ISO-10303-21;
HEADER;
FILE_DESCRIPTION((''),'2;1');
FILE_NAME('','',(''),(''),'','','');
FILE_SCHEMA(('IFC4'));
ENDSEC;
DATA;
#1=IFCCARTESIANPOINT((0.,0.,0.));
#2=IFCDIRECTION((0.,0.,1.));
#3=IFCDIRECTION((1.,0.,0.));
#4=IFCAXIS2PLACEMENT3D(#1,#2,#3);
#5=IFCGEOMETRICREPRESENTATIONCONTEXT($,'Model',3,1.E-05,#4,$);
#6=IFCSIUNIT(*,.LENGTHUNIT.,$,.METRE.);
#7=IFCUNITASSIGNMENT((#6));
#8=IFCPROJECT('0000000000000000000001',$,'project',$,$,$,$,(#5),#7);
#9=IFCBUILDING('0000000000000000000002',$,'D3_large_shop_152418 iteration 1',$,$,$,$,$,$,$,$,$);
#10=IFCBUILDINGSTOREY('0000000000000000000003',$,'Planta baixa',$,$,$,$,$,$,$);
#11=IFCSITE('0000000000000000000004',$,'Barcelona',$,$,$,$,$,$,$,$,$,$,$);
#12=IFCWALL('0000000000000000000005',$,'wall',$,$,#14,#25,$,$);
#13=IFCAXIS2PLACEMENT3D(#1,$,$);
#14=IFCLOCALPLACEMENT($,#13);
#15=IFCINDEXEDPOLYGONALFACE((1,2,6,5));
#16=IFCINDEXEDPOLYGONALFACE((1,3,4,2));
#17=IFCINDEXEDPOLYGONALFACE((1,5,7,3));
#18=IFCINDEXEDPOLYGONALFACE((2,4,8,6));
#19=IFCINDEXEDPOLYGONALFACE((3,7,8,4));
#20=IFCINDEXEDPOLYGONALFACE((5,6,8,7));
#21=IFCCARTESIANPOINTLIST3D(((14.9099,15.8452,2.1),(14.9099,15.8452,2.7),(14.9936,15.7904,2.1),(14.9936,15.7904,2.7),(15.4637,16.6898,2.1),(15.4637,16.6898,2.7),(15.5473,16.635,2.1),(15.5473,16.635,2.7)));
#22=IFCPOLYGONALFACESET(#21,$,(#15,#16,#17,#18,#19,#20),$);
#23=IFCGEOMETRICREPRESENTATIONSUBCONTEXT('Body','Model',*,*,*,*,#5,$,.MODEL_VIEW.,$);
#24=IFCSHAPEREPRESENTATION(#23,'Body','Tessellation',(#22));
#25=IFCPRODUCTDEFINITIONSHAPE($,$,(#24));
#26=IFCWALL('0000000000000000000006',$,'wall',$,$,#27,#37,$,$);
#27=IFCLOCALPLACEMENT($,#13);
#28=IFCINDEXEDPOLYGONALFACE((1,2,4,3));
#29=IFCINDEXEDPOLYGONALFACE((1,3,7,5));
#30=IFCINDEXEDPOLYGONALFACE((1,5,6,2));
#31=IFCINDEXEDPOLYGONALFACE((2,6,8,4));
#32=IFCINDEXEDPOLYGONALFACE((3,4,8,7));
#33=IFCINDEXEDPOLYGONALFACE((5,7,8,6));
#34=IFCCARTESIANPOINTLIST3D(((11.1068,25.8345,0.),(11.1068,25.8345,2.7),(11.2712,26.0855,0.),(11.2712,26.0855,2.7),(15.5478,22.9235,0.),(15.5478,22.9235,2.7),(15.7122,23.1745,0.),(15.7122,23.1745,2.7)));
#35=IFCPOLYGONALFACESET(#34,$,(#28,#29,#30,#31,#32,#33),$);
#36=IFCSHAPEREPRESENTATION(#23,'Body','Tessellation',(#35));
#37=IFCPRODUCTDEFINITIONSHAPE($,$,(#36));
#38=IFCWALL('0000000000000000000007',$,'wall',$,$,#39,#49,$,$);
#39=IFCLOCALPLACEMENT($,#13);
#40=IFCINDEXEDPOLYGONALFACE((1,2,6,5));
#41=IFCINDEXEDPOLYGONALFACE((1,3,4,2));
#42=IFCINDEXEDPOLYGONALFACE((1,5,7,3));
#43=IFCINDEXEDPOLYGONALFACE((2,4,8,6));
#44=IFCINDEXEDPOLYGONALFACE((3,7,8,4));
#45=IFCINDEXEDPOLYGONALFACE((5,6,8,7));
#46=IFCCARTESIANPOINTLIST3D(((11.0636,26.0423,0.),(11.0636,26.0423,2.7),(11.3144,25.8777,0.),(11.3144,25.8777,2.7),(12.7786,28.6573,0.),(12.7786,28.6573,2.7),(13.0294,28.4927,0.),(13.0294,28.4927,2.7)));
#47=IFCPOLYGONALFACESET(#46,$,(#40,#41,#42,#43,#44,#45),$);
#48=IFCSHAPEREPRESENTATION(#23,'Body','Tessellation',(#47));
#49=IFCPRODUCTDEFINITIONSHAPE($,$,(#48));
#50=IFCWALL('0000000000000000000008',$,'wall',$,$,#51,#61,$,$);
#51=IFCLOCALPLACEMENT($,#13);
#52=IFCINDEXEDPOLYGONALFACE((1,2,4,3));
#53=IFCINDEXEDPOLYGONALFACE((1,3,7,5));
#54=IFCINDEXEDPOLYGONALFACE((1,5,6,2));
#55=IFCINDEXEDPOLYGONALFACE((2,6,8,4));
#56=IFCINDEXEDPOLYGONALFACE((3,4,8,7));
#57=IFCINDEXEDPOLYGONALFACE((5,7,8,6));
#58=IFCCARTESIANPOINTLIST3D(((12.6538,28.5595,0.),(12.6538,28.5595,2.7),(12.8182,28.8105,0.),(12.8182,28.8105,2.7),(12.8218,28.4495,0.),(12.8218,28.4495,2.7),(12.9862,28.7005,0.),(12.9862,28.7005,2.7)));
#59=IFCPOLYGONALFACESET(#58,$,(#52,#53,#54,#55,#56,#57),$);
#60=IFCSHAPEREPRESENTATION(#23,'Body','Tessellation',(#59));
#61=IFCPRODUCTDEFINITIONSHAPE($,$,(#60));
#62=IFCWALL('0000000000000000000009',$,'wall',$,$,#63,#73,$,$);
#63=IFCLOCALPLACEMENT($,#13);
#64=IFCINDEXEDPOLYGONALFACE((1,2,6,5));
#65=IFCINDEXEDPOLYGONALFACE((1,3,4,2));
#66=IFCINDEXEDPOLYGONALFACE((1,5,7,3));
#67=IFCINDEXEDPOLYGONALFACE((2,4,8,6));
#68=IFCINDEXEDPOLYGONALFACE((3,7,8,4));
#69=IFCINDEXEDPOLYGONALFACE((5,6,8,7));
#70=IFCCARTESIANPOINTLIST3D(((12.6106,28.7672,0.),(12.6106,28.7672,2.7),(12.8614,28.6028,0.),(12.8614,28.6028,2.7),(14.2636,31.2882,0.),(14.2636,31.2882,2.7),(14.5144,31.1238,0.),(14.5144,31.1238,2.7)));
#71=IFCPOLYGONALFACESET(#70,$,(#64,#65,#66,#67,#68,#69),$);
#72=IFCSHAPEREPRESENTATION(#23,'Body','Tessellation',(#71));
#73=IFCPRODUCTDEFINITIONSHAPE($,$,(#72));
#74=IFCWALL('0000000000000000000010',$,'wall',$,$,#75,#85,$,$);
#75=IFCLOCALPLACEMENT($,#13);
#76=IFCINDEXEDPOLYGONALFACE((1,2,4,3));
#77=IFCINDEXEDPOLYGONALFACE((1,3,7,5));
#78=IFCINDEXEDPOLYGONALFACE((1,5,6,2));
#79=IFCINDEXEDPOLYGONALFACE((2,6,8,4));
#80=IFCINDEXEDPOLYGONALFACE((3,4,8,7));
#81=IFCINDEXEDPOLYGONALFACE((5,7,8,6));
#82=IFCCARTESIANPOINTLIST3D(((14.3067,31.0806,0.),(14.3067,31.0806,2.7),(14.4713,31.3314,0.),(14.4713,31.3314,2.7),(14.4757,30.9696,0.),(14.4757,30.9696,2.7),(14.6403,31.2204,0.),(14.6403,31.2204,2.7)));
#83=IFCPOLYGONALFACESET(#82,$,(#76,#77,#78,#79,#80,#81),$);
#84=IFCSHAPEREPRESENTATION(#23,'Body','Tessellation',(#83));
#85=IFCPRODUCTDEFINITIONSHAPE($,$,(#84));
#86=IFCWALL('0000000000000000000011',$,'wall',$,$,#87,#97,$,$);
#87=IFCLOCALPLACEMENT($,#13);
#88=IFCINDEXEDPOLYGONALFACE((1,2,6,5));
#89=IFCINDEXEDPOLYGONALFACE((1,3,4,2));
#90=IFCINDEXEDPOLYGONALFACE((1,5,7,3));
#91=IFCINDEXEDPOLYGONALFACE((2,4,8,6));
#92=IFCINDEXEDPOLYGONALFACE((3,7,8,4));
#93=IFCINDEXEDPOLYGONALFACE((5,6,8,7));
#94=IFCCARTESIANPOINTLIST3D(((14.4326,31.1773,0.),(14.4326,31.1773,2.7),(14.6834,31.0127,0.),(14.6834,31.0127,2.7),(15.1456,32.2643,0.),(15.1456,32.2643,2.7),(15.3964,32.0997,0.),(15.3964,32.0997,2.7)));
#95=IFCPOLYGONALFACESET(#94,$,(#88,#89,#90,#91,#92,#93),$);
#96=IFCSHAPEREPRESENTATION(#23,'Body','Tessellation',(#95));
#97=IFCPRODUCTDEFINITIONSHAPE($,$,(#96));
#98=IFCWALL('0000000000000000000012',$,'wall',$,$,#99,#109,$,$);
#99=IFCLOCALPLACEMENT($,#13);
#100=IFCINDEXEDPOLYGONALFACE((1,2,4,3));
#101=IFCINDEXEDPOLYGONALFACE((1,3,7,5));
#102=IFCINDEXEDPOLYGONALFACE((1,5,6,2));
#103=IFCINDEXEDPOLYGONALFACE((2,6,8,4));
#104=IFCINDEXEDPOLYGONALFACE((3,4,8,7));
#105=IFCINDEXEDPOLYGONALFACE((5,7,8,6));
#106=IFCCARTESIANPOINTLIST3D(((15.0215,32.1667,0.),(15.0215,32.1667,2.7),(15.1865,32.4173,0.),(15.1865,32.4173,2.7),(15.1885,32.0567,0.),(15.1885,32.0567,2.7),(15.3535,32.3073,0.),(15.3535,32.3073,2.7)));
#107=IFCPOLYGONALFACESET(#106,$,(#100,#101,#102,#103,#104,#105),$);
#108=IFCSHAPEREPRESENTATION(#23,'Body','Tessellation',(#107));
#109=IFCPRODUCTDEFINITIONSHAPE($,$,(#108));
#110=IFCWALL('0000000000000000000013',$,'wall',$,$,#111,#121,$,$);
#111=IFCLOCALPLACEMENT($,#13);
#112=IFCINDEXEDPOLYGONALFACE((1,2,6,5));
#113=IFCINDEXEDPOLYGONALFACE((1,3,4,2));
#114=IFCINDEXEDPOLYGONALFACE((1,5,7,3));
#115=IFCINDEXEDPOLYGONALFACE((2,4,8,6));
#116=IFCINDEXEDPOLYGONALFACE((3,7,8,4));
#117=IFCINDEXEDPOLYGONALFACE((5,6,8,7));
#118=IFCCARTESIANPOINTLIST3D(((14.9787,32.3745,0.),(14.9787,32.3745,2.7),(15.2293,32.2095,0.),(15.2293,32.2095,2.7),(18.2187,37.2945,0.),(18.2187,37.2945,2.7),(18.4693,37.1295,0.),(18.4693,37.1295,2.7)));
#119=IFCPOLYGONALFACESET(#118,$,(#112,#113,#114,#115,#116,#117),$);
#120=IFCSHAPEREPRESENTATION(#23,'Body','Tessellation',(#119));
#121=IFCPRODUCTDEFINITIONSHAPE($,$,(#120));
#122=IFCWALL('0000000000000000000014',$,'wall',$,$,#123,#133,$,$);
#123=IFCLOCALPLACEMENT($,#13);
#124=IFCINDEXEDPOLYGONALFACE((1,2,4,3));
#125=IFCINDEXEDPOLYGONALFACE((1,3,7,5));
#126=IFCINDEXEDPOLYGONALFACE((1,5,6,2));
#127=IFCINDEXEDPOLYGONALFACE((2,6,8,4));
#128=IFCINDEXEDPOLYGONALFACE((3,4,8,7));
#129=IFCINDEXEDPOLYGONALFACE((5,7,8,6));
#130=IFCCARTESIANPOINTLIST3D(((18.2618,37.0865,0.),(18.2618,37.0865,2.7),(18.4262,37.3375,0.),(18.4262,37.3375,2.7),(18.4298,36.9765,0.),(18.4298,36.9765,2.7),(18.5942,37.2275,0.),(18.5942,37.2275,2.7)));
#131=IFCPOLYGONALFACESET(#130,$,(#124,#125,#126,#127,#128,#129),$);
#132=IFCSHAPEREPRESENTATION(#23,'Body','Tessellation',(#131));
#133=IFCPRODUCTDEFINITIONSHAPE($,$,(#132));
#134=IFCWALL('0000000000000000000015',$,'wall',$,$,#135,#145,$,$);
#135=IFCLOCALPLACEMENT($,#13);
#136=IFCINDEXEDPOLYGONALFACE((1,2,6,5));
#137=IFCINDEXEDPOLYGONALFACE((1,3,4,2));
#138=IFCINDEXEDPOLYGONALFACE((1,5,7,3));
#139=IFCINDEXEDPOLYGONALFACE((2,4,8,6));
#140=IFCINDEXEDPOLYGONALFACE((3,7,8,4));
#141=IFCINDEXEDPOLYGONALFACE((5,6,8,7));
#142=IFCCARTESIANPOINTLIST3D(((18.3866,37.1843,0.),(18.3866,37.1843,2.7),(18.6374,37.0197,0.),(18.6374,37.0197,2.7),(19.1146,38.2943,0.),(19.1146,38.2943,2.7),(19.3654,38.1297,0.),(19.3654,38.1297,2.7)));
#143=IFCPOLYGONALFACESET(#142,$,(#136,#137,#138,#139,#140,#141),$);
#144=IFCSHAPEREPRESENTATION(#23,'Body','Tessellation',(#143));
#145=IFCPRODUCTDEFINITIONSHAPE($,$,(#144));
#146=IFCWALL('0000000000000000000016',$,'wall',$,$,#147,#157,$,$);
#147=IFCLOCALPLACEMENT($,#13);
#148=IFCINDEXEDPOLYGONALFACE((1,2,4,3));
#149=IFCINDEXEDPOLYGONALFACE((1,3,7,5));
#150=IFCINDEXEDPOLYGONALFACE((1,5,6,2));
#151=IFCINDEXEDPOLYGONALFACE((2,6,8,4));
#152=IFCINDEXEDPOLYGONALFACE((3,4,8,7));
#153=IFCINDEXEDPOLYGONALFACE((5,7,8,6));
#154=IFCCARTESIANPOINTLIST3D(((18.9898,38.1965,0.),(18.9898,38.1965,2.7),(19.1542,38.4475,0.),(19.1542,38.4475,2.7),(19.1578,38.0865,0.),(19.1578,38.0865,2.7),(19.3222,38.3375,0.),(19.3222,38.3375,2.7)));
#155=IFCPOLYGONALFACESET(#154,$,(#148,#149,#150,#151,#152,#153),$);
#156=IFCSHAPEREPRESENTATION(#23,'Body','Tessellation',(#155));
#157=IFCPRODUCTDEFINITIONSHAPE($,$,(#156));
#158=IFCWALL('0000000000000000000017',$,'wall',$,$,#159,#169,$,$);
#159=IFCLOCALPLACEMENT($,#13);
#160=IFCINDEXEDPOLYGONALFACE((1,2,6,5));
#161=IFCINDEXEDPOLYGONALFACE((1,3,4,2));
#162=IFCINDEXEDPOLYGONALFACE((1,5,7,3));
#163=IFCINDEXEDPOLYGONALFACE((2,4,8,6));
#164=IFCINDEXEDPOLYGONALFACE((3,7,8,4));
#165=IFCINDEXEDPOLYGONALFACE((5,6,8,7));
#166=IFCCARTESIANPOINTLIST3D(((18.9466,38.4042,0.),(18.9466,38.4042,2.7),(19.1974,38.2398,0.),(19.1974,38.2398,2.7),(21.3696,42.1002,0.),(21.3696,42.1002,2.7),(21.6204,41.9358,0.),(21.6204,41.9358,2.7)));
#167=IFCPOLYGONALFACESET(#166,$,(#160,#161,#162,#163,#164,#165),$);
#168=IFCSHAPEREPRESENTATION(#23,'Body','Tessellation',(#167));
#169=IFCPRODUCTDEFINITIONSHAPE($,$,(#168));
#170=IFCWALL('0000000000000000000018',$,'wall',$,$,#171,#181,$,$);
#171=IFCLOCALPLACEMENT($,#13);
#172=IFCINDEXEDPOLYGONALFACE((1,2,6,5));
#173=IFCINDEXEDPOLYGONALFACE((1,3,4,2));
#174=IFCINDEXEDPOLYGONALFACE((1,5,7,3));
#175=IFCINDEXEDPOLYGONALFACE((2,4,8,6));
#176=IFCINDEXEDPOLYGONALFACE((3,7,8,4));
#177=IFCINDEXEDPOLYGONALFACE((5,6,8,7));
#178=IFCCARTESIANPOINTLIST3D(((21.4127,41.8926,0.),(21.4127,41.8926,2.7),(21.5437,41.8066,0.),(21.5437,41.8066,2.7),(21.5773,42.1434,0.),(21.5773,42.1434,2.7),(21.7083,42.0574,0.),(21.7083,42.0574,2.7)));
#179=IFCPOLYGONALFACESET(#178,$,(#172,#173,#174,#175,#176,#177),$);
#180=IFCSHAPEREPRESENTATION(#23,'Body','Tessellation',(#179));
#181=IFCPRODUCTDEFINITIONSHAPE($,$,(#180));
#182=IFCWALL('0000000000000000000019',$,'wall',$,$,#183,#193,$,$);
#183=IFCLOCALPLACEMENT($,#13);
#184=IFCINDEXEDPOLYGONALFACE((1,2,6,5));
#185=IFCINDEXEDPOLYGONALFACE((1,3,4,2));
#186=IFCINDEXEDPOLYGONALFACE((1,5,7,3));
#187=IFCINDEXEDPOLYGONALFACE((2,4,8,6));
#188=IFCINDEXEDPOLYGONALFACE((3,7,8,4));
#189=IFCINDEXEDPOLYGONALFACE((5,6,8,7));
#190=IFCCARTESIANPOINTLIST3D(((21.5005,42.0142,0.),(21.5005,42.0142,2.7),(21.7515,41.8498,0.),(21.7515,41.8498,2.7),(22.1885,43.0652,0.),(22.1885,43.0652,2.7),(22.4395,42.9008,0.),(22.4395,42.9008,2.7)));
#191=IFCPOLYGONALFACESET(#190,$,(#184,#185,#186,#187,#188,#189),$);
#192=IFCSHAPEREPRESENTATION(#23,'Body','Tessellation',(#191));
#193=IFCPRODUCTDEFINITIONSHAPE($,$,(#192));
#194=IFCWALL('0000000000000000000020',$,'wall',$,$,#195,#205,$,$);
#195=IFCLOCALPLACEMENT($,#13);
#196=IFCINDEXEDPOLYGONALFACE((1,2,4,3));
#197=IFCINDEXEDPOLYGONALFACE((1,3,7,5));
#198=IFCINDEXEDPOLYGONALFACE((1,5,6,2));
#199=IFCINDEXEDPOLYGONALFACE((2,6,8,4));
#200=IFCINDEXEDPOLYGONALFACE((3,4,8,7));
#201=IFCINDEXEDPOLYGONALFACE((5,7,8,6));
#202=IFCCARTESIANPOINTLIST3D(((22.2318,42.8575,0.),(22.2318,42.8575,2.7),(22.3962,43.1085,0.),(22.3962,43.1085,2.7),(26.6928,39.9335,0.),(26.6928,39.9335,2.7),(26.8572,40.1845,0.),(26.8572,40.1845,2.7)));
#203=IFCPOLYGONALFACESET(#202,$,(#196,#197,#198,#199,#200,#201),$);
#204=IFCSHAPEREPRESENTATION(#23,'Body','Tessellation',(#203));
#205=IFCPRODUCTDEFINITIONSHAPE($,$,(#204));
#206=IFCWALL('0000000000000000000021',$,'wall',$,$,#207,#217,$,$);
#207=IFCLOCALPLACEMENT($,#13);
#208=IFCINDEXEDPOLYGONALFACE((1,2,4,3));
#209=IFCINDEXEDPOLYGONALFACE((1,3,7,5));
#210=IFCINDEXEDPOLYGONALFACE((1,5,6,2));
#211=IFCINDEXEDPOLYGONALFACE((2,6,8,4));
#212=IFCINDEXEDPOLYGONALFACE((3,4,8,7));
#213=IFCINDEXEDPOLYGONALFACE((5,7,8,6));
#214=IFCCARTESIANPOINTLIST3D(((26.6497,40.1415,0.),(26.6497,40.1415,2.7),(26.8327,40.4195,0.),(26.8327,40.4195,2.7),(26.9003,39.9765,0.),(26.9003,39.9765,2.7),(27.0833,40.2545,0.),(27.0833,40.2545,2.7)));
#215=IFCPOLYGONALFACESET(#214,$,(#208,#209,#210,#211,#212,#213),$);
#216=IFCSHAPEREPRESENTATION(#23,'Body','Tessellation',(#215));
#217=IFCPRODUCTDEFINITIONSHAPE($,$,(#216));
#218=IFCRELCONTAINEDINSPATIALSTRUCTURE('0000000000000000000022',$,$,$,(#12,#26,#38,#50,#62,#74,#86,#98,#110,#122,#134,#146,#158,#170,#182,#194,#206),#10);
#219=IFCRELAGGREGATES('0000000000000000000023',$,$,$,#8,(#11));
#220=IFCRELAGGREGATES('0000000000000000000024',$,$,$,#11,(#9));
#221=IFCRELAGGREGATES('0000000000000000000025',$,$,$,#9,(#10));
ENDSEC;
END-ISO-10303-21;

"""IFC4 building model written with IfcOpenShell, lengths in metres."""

from ifc_helpers import new_model, si_unit, frame, origin, origin_with_axes, place, context, subcontext, project, spatial, polyline, outline, extrude, element, save


model = new_model("IFC4")

# Units and contexts
model_context = context("Model", 3, precision=1e-05, world=origin_with_axes())
body_context = subcontext(model_context, "Body", "Model", "MODEL_VIEW")
ifc_project = project(units=[si_unit("LENGTHUNIT", "METRE")], contexts=[model_context])

# Site, building, storey
site = spatial("IfcSite", under=ifc_project, Name="Barcelona")
building = spatial("IfcBuilding", under=site, Name="D3_large_shop_152418 iteration 1")
storey = spatial("IfcBuildingStorey", under=building, Name="Planta baixa")

# Walls
wall_1_placement = place(None, origin_with_axes())
element("IfcWall", 1, at=wall_1_placement, inside=storey, Name="wall", context=body_context, shape_type="SweptSolid", body=[
    extrude(outline(polyline([(14.9099, 15.8452), (15.4637, 16.6898), (15.5473, 16.635), (14.9936, 15.7904), (14.9099, 15.8452)])), frame((0.0, 0.0, 2.1)), (0.0, 0.0, 1.0), 0.6),
])
wall_2_placement = place(None, origin_with_axes())
element("IfcWall", 2, at=wall_2_placement, inside=storey, Name="wall", context=body_context, shape_type="SweptSolid", body=[
    extrude(outline(polyline([(15.5478, 22.9235), (11.1068, 25.8345), (11.2712, 26.0855), (15.7122, 23.1745), (15.5478, 22.9235)])), origin(), (0.0, 0.0, 1.0), 2.7),
])
wall_3_placement = place(None, origin_with_axes())
element("IfcWall", 3, at=wall_3_placement, inside=storey, Name="wall", context=body_context, shape_type="SweptSolid", body=[
    extrude(outline(polyline([(11.0636, 26.0423), (12.7786, 28.6573), (13.0294, 28.4927), (11.3144, 25.8777), (11.0636, 26.0423)])), origin(), (0.0, 0.0, 1.0), 2.7),
])
wall_4_placement = place(None, origin_with_axes())
element("IfcWall", 4, at=wall_4_placement, inside=storey, Name="wall", context=body_context, shape_type="SweptSolid", body=[
    extrude(outline(polyline([(12.8218, 28.4495), (12.6538, 28.5595), (12.8182, 28.8105), (12.9862, 28.7005), (12.8218, 28.4495)])), origin(), (0.0, 0.0, 1.0), 2.7),
])
wall_5_placement = place(None, origin_with_axes())
element("IfcWall", 5, at=wall_5_placement, inside=storey, Name="wall", context=body_context, shape_type="SweptSolid", body=[
    extrude(outline(polyline([(12.6106, 28.7672), (14.2636, 31.2882), (14.5144, 31.1238), (12.8614, 28.6028), (12.6106, 28.7672)])), origin(), (0.0, 0.0, 1.0), 2.7),
])
wall_6_placement = place(None, origin_with_axes())
element("IfcWall", 6, at=wall_6_placement, inside=storey, Name="wall", context=body_context, shape_type="SweptSolid", body=[
    extrude(outline(polyline([(14.4713, 31.3314), (14.6403, 31.2204), (14.4757, 30.9696), (14.3067, 31.0806), (14.4713, 31.3314)])), origin(), (0.0, 0.0, 1.0), 2.7),
])
wall_7_placement = place(None, origin_with_axes())
element("IfcWall", 7, at=wall_7_placement, inside=storey, Name="wall", context=body_context, shape_type="SweptSolid", body=[
    extrude(outline(polyline([(14.4326, 31.1773), (15.1456, 32.2643), (15.3964, 32.0997), (14.6834, 31.0127), (14.4326, 31.1773)])), origin(), (0.0, 0.0, 1.0), 2.7),
])
wall_8_placement = place(None, origin_with_axes())
element("IfcWall", 8, at=wall_8_placement, inside=storey, Name="wall", context=body_context, shape_type="SweptSolid", body=[
    extrude(outline(polyline([(15.1885, 32.0567), (15.0215, 32.1667), (15.1865, 32.4173), (15.3535, 32.3073), (15.1885, 32.0567)])), origin(), (0.0, 0.0, 1.0), 2.7),
])
wall_9_placement = place(None, origin_with_axes())
element("IfcWall", 9, at=wall_9_placement, inside=storey, Name="wall", context=body_context, shape_type="SweptSolid", body=[
    extrude(outline(polyline([(14.9787, 32.3745), (18.2187, 37.2945), (18.4693, 37.1295), (15.2293, 32.2095), (14.9787, 32.3745)])), origin(), (0.0, 0.0, 1.0), 2.7),
])
wall_10_placement = place(None, origin_with_axes())
element("IfcWall", 10, at=wall_10_placement, inside=storey, Name="wall", context=body_context, shape_type="SweptSolid", body=[
    extrude(outline(polyline([(18.4262, 37.3375), (18.5942, 37.2275), (18.4298, 36.9765), (18.2618, 37.0865), (18.4262, 37.3375)])), origin(), (0.0, 0.0, 1.0), 2.7),
])
wall_11_placement = place(None, origin_with_axes())
element("IfcWall", 11, at=wall_11_placement, inside=storey, Name="wall", context=body_context, shape_type="SweptSolid", body=[
    extrude(outline(polyline([(18.3866, 37.1843), (19.1146, 38.2943), (19.3654, 38.1297), (18.6374, 37.0197), (18.3866, 37.1843)])), origin(), (0.0, 0.0, 1.0), 2.7),
])
wall_12_placement = place(None, origin_with_axes())
element("IfcWall", 12, at=wall_12_placement, inside=storey, Name="wall", context=body_context, shape_type="SweptSolid", body=[
    extrude(outline(polyline([(19.1578, 38.0865), (18.9898, 38.1965), (19.1542, 38.4475), (19.3222, 38.3375), (19.1578, 38.0865)])), origin(), (0.0, 0.0, 1.0), 2.7),
])
wall_13_placement = place(None, origin_with_axes())
element("IfcWall", 13, at=wall_13_placement, inside=storey, Name="wall", context=body_context, shape_type="SweptSolid", body=[
    extrude(outline(polyline([(18.9466, 38.4042), (21.3696, 42.1002), (21.6204, 41.9358), (19.1974, 38.2398), (18.9466, 38.4042)])), origin(), (0.0, 0.0, 1.0), 2.7),
])
wall_14_placement = place(None, origin_with_axes())
element("IfcWall", 14, at=wall_14_placement, inside=storey, Name="wall", context=body_context, shape_type="SweptSolid", body=[
    extrude(outline(polyline([(21.5773, 42.1434), (21.7083, 42.0574), (21.5437, 41.8066), (21.4127, 41.8926), (21.5773, 42.1434)])), origin(), (0.0, 0.0, 1.0), 2.7),
])
wall_15_placement = place(None, origin_with_axes())
element("IfcWall", 15, at=wall_15_placement, inside=storey, Name="wall", context=body_context, shape_type="SweptSolid", body=[
    extrude(outline(polyline([(21.5005, 42.0142), (22.1885, 43.0652), (22.4395, 42.9008), (21.7515, 41.8498), (21.5005, 42.0142)])), origin(), (0.0, 0.0, 1.0), 2.7),
])
wall_16_placement = place(None, origin_with_axes())
element("IfcWall", 16, at=wall_16_placement, inside=storey, Name="wall", context=body_context, shape_type="SweptSolid", body=[
    extrude(outline(polyline([(22.3962, 43.1085), (26.8572, 40.1845), (26.6928, 39.9335), (22.2318, 42.8575), (22.3962, 43.1085)])), origin(), (0.0, 0.0, 1.0), 2.7),
])
wall_17_placement = place(None, origin_with_axes())
element("IfcWall", 17, at=wall_17_placement, inside=storey, Name="wall", context=body_context, shape_type="SweptSolid", body=[
    extrude(outline(polyline([(26.6497, 40.1415), (26.8327, 40.4195), (27.0833, 40.2545), (26.9003, 39.9765), (26.6497, 40.1415)])), origin(), (0.0, 0.0, 1.0), 2.7),
])

save(model, "model.ifc")
